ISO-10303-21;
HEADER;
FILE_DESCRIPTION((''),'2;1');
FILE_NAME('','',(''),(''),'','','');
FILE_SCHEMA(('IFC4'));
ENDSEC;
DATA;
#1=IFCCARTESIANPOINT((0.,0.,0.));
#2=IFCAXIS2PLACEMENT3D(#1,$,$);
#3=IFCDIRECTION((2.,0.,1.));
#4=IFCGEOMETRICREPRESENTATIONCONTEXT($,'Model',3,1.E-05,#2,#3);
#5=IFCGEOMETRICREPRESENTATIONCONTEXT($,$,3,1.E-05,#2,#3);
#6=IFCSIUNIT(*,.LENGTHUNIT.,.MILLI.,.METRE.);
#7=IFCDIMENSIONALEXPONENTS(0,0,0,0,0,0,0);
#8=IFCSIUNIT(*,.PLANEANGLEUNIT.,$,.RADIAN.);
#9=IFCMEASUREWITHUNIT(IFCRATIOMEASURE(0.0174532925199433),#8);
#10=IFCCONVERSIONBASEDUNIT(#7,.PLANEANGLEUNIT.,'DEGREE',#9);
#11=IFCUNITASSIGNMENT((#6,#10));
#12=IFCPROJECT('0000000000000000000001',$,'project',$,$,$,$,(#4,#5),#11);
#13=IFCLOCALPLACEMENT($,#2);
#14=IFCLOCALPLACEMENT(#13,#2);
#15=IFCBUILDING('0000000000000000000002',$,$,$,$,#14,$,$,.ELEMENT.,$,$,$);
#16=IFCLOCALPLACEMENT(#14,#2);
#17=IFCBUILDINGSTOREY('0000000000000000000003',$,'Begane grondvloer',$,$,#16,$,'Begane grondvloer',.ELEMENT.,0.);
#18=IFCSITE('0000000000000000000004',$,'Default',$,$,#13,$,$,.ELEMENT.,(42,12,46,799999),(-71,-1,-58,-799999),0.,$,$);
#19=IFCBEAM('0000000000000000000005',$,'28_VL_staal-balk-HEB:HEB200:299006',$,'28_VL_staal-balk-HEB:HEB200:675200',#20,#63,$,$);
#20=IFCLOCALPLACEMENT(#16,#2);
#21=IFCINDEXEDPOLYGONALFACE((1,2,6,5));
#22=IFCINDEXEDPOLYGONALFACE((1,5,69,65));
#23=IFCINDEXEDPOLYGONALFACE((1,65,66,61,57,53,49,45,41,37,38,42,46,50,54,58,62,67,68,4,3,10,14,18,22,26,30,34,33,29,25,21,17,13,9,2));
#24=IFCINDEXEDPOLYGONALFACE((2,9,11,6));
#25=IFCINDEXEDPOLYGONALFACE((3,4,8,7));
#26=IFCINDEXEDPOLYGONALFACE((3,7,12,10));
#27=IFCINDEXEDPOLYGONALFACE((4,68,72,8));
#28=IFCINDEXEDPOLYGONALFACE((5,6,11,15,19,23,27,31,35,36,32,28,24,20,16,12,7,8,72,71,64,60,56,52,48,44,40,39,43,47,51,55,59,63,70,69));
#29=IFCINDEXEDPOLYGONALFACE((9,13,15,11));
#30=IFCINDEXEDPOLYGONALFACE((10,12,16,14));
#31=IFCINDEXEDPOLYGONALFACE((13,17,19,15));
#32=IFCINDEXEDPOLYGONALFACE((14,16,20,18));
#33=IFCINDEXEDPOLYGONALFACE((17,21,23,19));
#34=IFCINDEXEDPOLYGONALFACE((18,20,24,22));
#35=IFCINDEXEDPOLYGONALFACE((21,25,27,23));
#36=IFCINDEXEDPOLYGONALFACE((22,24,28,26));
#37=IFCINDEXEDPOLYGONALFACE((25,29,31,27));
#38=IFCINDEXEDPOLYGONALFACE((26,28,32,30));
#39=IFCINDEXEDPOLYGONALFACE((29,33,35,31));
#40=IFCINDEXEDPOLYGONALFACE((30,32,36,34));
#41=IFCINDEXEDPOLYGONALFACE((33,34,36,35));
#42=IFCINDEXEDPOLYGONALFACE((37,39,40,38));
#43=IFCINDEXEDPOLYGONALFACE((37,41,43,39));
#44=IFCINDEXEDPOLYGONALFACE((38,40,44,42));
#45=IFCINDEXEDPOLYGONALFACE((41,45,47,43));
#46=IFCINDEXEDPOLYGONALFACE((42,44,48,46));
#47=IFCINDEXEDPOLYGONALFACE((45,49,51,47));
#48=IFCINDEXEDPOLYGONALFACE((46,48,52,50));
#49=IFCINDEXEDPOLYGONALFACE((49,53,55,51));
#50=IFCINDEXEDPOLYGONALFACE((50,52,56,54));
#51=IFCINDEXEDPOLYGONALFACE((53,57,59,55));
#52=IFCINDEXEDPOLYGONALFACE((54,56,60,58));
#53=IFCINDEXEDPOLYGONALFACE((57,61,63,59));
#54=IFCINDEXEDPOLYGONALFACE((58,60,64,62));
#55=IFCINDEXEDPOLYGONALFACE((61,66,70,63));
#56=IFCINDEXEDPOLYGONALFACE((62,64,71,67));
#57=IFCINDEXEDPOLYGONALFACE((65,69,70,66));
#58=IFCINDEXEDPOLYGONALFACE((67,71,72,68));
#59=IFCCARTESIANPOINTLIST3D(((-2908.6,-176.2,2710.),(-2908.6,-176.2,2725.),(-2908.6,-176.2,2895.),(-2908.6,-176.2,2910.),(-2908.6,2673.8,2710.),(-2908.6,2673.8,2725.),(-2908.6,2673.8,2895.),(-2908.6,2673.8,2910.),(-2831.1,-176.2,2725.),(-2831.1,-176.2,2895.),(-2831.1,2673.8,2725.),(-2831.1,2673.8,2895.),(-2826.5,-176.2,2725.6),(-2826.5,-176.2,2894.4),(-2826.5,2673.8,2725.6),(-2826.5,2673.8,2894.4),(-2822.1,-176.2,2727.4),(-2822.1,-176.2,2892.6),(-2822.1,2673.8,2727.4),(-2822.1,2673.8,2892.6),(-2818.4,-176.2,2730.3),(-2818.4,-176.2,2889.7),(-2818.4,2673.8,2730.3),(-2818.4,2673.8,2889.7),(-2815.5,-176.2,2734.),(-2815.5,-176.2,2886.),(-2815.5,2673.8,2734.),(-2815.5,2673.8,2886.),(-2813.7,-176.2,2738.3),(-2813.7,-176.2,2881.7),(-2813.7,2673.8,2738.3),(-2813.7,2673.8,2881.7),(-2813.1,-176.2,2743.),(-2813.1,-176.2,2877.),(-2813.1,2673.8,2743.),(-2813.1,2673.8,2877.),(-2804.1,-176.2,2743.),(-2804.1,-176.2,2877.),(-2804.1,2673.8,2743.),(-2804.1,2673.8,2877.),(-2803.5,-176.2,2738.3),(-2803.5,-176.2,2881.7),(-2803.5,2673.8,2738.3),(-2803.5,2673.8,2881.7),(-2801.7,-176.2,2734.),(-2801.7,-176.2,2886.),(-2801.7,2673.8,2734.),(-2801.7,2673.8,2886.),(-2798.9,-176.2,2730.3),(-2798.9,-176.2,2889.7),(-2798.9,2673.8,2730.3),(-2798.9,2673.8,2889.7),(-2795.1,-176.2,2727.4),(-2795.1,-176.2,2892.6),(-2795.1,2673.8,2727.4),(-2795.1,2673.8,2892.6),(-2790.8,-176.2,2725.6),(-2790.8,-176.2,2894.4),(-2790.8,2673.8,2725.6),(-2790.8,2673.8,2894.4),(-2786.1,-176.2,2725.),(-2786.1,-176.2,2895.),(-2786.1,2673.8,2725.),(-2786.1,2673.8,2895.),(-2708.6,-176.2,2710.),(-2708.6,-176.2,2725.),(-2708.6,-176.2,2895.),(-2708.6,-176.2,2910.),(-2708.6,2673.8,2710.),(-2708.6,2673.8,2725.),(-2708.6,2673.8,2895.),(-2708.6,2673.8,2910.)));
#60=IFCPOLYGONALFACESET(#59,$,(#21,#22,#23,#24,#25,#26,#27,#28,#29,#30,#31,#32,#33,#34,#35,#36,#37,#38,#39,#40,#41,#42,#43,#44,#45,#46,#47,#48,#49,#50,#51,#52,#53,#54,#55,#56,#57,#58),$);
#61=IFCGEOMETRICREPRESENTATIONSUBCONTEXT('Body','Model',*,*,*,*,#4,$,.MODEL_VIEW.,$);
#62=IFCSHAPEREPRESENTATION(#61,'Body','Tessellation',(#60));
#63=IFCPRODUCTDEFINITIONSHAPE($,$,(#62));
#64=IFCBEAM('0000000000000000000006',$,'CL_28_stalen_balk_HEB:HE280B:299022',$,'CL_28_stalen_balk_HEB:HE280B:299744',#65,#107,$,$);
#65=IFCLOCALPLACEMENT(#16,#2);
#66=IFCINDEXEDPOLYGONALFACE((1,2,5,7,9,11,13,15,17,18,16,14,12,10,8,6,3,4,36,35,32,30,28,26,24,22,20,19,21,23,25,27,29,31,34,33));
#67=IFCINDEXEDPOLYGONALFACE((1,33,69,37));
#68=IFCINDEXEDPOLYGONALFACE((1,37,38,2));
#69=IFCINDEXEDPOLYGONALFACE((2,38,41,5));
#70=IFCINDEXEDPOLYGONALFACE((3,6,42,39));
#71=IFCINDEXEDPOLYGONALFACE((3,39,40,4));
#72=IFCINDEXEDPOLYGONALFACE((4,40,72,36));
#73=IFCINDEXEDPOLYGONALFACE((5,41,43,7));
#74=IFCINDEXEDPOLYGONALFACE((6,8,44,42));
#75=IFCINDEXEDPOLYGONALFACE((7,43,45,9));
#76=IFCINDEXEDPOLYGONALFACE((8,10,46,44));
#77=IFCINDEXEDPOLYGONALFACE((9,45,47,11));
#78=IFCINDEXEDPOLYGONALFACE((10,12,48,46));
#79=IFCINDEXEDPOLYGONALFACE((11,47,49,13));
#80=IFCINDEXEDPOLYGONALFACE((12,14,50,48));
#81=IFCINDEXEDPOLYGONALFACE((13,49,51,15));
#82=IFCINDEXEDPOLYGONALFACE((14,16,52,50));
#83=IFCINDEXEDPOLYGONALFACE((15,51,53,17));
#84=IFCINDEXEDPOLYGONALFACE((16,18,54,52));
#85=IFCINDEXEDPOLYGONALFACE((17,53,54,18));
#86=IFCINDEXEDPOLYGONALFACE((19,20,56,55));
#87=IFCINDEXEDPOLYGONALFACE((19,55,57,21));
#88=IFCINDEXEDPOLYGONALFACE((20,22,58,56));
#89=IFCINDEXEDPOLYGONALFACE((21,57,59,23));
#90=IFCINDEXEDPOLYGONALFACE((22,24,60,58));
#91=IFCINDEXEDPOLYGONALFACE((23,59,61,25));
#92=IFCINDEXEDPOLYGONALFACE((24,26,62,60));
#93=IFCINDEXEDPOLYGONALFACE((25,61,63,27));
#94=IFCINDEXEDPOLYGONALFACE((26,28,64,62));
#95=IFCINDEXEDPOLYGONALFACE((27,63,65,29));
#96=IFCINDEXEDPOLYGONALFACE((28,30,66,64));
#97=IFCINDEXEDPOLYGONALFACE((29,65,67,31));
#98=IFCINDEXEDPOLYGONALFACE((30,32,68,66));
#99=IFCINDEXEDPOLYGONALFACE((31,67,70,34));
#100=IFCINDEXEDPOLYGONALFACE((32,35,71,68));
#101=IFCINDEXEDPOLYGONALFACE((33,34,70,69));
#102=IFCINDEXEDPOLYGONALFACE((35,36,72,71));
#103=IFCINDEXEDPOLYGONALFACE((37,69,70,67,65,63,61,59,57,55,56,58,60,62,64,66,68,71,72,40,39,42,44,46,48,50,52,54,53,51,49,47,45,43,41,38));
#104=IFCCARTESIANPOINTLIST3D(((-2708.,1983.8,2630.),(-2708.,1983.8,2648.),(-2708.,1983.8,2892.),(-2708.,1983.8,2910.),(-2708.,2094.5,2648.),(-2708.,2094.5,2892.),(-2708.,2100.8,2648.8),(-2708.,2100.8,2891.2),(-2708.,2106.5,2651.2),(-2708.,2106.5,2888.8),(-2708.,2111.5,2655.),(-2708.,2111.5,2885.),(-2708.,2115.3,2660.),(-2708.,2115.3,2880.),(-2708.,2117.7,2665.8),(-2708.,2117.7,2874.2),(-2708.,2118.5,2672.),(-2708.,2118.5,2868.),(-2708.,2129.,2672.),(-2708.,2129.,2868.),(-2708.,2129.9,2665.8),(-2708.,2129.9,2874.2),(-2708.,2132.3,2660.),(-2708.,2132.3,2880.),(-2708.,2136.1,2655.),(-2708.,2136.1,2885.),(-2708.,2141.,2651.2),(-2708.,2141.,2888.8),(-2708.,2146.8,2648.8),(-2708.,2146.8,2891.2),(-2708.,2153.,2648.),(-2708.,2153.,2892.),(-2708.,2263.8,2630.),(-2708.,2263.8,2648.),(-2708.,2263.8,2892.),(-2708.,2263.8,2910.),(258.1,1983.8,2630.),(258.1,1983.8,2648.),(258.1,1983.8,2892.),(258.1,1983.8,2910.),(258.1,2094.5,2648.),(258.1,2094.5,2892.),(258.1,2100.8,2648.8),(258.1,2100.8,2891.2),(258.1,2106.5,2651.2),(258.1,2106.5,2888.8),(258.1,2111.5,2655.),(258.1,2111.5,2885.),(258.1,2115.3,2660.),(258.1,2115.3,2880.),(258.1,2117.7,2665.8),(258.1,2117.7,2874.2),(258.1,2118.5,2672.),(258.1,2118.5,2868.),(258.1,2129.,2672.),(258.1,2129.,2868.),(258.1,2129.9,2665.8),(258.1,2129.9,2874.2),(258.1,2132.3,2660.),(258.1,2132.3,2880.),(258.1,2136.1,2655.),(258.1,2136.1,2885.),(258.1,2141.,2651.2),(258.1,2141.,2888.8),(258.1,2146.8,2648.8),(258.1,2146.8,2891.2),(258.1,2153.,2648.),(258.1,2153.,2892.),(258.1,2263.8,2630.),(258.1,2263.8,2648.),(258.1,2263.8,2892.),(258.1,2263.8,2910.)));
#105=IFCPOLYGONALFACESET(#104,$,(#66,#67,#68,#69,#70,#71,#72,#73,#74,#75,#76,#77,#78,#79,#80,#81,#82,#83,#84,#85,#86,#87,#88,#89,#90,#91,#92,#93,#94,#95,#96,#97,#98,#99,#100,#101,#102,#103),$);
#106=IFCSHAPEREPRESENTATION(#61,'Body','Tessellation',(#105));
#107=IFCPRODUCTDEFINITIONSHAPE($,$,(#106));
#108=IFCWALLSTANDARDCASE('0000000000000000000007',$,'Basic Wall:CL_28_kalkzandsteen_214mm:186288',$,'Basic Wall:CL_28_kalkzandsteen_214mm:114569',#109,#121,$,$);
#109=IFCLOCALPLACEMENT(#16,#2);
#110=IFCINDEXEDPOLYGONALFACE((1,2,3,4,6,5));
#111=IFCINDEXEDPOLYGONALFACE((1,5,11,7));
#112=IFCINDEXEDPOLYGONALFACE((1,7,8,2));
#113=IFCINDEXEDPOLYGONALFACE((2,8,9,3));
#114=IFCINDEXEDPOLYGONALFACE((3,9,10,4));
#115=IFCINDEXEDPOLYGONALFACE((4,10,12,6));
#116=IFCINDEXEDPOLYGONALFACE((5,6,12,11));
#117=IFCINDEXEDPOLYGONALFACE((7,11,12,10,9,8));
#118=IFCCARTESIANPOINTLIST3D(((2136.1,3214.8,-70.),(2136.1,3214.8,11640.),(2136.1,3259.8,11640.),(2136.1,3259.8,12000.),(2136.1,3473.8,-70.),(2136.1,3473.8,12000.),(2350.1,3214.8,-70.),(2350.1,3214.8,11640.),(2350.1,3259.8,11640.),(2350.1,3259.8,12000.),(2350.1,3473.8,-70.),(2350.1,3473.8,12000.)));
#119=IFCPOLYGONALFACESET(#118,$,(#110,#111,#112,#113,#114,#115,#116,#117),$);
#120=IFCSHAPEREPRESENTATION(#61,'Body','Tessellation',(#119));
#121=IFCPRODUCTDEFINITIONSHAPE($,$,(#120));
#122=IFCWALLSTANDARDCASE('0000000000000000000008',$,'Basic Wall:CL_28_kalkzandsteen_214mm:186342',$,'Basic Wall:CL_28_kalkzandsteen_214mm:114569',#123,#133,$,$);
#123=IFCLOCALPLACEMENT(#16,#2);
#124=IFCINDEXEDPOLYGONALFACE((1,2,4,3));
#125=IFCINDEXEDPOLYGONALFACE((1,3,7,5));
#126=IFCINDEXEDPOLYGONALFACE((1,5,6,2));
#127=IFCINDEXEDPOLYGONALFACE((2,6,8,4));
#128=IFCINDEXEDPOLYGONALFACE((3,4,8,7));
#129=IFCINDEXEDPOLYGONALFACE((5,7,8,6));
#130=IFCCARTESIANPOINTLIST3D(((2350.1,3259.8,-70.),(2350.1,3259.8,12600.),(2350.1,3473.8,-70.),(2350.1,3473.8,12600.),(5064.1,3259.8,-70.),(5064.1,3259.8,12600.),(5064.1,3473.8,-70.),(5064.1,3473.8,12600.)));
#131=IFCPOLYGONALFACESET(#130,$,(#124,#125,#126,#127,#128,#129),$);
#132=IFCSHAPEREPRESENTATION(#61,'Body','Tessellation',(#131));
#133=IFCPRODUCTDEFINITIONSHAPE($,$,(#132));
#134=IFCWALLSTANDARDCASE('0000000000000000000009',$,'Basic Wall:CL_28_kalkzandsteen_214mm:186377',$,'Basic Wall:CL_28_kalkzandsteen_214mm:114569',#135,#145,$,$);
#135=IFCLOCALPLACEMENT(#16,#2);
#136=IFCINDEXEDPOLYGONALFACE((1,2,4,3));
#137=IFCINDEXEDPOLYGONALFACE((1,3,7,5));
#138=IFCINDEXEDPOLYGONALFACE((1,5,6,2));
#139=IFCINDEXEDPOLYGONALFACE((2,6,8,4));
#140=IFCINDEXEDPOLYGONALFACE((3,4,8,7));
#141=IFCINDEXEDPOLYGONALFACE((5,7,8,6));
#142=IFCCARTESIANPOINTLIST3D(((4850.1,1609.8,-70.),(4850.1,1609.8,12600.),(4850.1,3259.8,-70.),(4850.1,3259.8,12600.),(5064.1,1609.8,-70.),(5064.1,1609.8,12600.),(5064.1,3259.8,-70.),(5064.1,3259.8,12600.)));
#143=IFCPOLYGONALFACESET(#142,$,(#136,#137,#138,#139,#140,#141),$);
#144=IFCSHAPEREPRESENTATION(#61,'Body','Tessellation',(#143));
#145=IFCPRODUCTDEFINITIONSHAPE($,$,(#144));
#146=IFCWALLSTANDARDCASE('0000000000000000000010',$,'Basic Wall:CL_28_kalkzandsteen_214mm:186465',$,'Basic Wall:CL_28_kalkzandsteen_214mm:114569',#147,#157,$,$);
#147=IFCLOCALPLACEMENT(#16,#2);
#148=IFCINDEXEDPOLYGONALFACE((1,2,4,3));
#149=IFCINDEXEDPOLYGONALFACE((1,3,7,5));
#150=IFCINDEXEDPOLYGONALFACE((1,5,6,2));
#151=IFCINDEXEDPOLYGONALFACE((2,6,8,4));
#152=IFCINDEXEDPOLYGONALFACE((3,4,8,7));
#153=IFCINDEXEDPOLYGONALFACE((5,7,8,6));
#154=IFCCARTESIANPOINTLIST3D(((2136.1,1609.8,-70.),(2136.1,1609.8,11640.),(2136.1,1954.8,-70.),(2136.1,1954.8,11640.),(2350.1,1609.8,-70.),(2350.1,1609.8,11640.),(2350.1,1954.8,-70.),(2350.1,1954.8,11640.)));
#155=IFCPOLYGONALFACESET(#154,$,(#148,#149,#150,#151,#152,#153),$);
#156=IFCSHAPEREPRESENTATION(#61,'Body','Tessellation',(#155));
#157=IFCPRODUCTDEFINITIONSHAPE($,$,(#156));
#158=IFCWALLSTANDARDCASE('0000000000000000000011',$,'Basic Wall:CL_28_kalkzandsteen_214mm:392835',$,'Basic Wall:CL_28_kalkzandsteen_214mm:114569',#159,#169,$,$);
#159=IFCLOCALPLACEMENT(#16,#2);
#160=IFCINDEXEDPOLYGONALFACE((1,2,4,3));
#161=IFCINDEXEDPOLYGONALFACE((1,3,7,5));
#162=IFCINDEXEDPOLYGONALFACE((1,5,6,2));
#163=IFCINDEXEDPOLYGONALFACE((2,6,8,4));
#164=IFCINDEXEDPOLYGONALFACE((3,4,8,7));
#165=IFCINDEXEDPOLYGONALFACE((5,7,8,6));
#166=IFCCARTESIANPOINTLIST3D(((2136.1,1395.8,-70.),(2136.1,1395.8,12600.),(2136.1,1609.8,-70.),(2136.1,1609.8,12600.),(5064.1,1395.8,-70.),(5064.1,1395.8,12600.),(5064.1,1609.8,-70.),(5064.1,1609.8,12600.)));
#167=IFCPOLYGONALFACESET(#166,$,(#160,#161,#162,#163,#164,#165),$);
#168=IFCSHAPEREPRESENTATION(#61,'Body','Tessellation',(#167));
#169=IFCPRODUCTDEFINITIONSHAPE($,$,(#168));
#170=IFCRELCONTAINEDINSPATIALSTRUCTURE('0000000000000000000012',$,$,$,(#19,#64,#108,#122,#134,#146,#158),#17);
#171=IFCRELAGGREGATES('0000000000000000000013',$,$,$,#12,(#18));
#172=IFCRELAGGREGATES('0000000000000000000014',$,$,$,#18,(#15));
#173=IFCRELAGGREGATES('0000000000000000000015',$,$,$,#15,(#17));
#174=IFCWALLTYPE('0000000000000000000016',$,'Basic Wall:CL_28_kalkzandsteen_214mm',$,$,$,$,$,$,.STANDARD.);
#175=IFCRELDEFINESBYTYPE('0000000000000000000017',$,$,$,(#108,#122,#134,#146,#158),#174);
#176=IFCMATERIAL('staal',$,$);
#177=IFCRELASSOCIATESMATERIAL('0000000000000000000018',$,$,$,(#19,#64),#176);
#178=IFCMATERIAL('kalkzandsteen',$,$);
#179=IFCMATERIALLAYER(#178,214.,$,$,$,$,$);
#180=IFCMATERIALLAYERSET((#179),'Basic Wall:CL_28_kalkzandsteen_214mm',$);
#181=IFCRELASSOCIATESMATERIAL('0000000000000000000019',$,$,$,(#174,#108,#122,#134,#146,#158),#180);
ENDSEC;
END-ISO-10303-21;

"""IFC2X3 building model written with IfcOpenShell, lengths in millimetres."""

from ifc_helpers import new_model, entity, si_unit, converted_unit, direction, frame, frame_2d, origin, place, context, subcontext, project, spatial, polyline, rectangle, i_section, extrude, clip, bounded_halfspace, material, layer, layer_set, layer_usage, type_object, element, save


model = new_model("IFC2X3")

# Units and contexts
model_context = context("Model", 3, precision=1e-05, world=origin(), true_north=direction((2.0, 0.0, 1.0)))
context_of_model = context(None, 3, precision=1e-05, world=origin(), true_north=direction((2.0, 0.0, 1.0)))
body_context = subcontext(model_context, "Body", "Model", "MODEL_VIEW")
ifc_project = project(units=[si_unit("LENGTHUNIT", "METRE", prefix="MILLI"), converted_unit("PLANEANGLEUNIT", "DEGREE", entity("IfcRatioMeasure", 0.0174532925199433), si_unit("PLANEANGLEUNIT", "RADIAN"), dimensions=[0, 0, 0, 0, 0, 0, 0])], contexts=[model_context, context_of_model])

# Site, building, storey
site_placement = place(None, origin())
site = spatial("IfcSite", under=ifc_project, at=site_placement, Name="Default", CompositionType="ELEMENT", RefLatitude=(42, 12, 46, 799999), RefLongitude=(-71, -1, -58, -799999), RefElevation=0.0)
building_placement = place(site_placement, origin())
building = spatial("IfcBuilding", under=site, at=building_placement, CompositionType="ELEMENT")
storey_placement = place(building_placement, origin())
storey = spatial("IfcBuildingStorey", under=building, at=storey_placement, Name="Begane grondvloer", LongName="Begane grondvloer", CompositionType="ELEMENT", Elevation=0.0)

# Beams
ifc_material_1 = material(Name="staal")
beam_1_placement = place(storey_placement, frame((-2808.6, 173.8, 2910.0), z_axis=(0.0, 0.0, 1.0), x_axis=(0.0, 1.0, 0.0)))
element("IfcBeam", 1, at=beam_1_placement, inside=storey, material=ifc_material_1, Name="28_VL_staal-balk-HEB:HEB200:299006", ObjectType="28_VL_staal-balk-HEB:HEB200:675200", context=body_context, shape_type="SweptSolid", body=[
    extrude(i_section(OverallWidth=200.0, OverallDepth=200.0, WebThickness=9.0, FlangeThickness=15.0, FilletRadius=18.0, at=frame_2d((0.0, 0.0), x_axis=(0.0, 1.0))), frame((-350.0, 0.0, -100.0), z_axis=(1.0, 0.0, 0.0), x_axis=(0.0, 0.0, -1.0)), (0.0, 0.0, 1.0), 2850.0),
])
beam_2_placement = place(storey_placement, frame((-2708.6, 2123.8, 2910.0)))
element("IfcBeam", 2, at=beam_2_placement, inside=storey, material=ifc_material_1, Name="CL_28_stalen_balk_HEB:HE280B:299022", ObjectType="CL_28_stalen_balk_HEB:HE280B:299744", context=body_context, shape_type="SweptSolid", body=[
    extrude(i_section(OverallWidth=280.0, OverallDepth=280.0, WebThickness=10.5, FlangeThickness=18.0, FilletRadius=24.0, at=frame_2d((0.0, 0.0), x_axis=(0.0, 1.0))), frame((0.7, 0.0, -140.0), z_axis=(1.0, 0.0, 0.0), x_axis=(0.0, 0.0, -1.0)), (0.0, 0.0, 1.0), 2966.0),
])

# Walls
ifc_material_2 = material(Name="kalkzandsteen")
ifc_layer_1 = layer(ifc_material_2, 214.0)
ifc_layer_set_1 = layer_set([ifc_layer_1], Name="Basic Wall:CL_28_kalkzandsteen_214mm")
ifc_layer_usage_1 = layer_usage(ifc_layer_set_1, "AXIS2", "NEGATIVE", 107.0)
wall_type_1 = type_object("IfcWallType", Name="Basic Wall:CL_28_kalkzandsteen_214mm", PredefinedType="STANDARD", material=ifc_layer_set_1)
wall_1_placement = place(storey_placement, frame((2243.1, 3214.8, -70.0), z_axis=(0.0, 0.0, 1.0), x_axis=(0.0, 1.0, 0.0)))
element("IfcWallStandardCase", 3, at=wall_1_placement, inside=storey, type_object=wall_type_1, material=ifc_layer_usage_1, Name="Basic Wall:CL_28_kalkzandsteen_214mm:186288", ObjectType="Basic Wall:CL_28_kalkzandsteen_214mm:114569", context=body_context, shape_type="Clipping", body=[
    clip(clip(extrude(rectangle(XDim=259.0, YDim=214.0, at=frame_2d((129.5, 0.0), x_axis=(-1.0, 0.0))), origin(), (0.0, 0.0, 1.0), 12070.0), bounded_halfspace(frame((45.0, -107.0, 11710.0), z_axis=(0.0, 0.0, -1.0), x_axis=(0.0, 1.0, 0.0)), True, frame((45.0, -107.0, 11710.0), z_axis=(0.0, 0.0, -1.0), x_axis=(0.0, 1.0, 0.0)), polyline([(0.0, 0.0), (0.0, -45.0), (214.0, -45.0), (214.0, 0.0), (0.0, 0.0)]))), bounded_halfspace(frame((45.0, 107.0, 11710.0), z_axis=(-1.0, 0.0, 0.0), x_axis=(0.0, -1.0, 0.0)), False, frame((45.0, 107.0, 11710.0), z_axis=(-1.0, 0.0, 0.0), x_axis=(0.0, -1.0, 0.0)), polyline([(0.0, 0.0), (214.0, 0.0), (214.0, 360.0), (0.0, 360.0), (0.0, 0.0)]))),
])
ifc_layer_usage_2 = layer_usage(ifc_layer_set_1, "AXIS2", "NEGATIVE", 107.0)
wall_2_placement = place(storey_placement, frame((2136.1, 3366.8, -70.0)))
element("IfcWallStandardCase", 4, at=wall_2_placement, inside=storey, type_object=wall_type_1, material=ifc_layer_usage_2, Name="Basic Wall:CL_28_kalkzandsteen_214mm:186342", ObjectType="Basic Wall:CL_28_kalkzandsteen_214mm:114569", context=body_context, shape_type="Clipping", body=[
    clip(extrude(rectangle(XDim=2714.0, YDim=214.0, at=frame_2d((1571.0, 0.0), x_axis=(-1.0, 0.0))), origin(), (0.0, 0.0, 1.0), 12670.0), bounded_halfspace(frame((0.0, -107.0, 12670.0), z_axis=(0.0, 0.0, -1.0), x_axis=(0.0, -1.0, 0.0)), True, frame((0.0, -107.0, 12670.0)), polyline([(0.0, 0.0), (214.0, 0.0), (2714.0, 0.0), (2928.0, 0.0), (2928.0, 214.0), (0.0, 214.0), (0.0, 0.0)]))),
])
ifc_layer_usage_3 = layer_usage(ifc_layer_set_1, "AXIS2", "NEGATIVE", 107.0)
wall_3_placement = place(storey_placement, frame((4957.1, 3259.8, -70.0), z_axis=(0.0, 0.0, 1.0), x_axis=(0.0, -1.0, 0.0)))
element("IfcWallStandardCase", 5, at=wall_3_placement, inside=storey, type_object=wall_type_1, material=ifc_layer_usage_3, Name="Basic Wall:CL_28_kalkzandsteen_214mm:186377", ObjectType="Basic Wall:CL_28_kalkzandsteen_214mm:114569", context=body_context, shape_type="SweptSolid", body=[
    extrude(rectangle(XDim=1650.0, YDim=214.0, at=frame_2d((825.0, 0.0), x_axis=(-1.0, 0.0))), origin(), (0.0, 0.0, 1.0), 12670.0),
])
ifc_layer_usage_4 = layer_usage(ifc_layer_set_1, "AXIS2", "NEGATIVE", 107.0)
wall_4_placement = place(storey_placement, frame((2243.1, 1609.8, -70.0), z_axis=(0.0, 0.0, 1.0), x_axis=(0.0, 1.0, 0.0)))
element("IfcWallStandardCase", 6, at=wall_4_placement, inside=storey, type_object=wall_type_1, material=ifc_layer_usage_4, Name="Basic Wall:CL_28_kalkzandsteen_214mm:186465", ObjectType="Basic Wall:CL_28_kalkzandsteen_214mm:114569", context=body_context, shape_type="Clipping", body=[
    clip(extrude(rectangle(XDim=345.0, YDim=214.0, at=frame_2d((172.5, 0.0), x_axis=(-1.0, 0.0))), origin(), (0.0, 0.0, 1.0), 12070.0), bounded_halfspace(frame((0.0, -107.0, 11710.0), z_axis=(0.0, 0.0, -1.0), x_axis=(0.0, 1.0, 0.0)), True, frame((0.0, -107.0, 11710.0), z_axis=(0.0, 0.0, -1.0), x_axis=(0.0, 1.0, 0.0)), polyline([(0.0, 0.0), (214.0, 0.0), (214.0, 345.0), (0.0, 345.0), (0.0, 0.0)]))),
])
ifc_layer_usage_5 = layer_usage(ifc_layer_set_1, "AXIS2", "NEGATIVE", 107.0)
wall_5_placement = place(storey_placement, frame((5064.1, 1502.8, -70.0), z_axis=(0.0, 0.0, 1.0), x_axis=(-1.0, 0.0, 0.0)))
element("IfcWallStandardCase", 7, at=wall_5_placement, inside=storey, type_object=wall_type_1, material=ifc_layer_usage_5, Name="Basic Wall:CL_28_kalkzandsteen_214mm:392835", ObjectType="Basic Wall:CL_28_kalkzandsteen_214mm:114569", context=body_context, shape_type="SweptSolid", body=[
    extrude(rectangle(XDim=2928.0, YDim=214.0, at=frame_2d((1464.0, 0.0), x_axis=(-1.0, 0.0))), origin(), (0.0, 0.0, 1.0), 12670.0),
])

save(model, "model.ifc")
